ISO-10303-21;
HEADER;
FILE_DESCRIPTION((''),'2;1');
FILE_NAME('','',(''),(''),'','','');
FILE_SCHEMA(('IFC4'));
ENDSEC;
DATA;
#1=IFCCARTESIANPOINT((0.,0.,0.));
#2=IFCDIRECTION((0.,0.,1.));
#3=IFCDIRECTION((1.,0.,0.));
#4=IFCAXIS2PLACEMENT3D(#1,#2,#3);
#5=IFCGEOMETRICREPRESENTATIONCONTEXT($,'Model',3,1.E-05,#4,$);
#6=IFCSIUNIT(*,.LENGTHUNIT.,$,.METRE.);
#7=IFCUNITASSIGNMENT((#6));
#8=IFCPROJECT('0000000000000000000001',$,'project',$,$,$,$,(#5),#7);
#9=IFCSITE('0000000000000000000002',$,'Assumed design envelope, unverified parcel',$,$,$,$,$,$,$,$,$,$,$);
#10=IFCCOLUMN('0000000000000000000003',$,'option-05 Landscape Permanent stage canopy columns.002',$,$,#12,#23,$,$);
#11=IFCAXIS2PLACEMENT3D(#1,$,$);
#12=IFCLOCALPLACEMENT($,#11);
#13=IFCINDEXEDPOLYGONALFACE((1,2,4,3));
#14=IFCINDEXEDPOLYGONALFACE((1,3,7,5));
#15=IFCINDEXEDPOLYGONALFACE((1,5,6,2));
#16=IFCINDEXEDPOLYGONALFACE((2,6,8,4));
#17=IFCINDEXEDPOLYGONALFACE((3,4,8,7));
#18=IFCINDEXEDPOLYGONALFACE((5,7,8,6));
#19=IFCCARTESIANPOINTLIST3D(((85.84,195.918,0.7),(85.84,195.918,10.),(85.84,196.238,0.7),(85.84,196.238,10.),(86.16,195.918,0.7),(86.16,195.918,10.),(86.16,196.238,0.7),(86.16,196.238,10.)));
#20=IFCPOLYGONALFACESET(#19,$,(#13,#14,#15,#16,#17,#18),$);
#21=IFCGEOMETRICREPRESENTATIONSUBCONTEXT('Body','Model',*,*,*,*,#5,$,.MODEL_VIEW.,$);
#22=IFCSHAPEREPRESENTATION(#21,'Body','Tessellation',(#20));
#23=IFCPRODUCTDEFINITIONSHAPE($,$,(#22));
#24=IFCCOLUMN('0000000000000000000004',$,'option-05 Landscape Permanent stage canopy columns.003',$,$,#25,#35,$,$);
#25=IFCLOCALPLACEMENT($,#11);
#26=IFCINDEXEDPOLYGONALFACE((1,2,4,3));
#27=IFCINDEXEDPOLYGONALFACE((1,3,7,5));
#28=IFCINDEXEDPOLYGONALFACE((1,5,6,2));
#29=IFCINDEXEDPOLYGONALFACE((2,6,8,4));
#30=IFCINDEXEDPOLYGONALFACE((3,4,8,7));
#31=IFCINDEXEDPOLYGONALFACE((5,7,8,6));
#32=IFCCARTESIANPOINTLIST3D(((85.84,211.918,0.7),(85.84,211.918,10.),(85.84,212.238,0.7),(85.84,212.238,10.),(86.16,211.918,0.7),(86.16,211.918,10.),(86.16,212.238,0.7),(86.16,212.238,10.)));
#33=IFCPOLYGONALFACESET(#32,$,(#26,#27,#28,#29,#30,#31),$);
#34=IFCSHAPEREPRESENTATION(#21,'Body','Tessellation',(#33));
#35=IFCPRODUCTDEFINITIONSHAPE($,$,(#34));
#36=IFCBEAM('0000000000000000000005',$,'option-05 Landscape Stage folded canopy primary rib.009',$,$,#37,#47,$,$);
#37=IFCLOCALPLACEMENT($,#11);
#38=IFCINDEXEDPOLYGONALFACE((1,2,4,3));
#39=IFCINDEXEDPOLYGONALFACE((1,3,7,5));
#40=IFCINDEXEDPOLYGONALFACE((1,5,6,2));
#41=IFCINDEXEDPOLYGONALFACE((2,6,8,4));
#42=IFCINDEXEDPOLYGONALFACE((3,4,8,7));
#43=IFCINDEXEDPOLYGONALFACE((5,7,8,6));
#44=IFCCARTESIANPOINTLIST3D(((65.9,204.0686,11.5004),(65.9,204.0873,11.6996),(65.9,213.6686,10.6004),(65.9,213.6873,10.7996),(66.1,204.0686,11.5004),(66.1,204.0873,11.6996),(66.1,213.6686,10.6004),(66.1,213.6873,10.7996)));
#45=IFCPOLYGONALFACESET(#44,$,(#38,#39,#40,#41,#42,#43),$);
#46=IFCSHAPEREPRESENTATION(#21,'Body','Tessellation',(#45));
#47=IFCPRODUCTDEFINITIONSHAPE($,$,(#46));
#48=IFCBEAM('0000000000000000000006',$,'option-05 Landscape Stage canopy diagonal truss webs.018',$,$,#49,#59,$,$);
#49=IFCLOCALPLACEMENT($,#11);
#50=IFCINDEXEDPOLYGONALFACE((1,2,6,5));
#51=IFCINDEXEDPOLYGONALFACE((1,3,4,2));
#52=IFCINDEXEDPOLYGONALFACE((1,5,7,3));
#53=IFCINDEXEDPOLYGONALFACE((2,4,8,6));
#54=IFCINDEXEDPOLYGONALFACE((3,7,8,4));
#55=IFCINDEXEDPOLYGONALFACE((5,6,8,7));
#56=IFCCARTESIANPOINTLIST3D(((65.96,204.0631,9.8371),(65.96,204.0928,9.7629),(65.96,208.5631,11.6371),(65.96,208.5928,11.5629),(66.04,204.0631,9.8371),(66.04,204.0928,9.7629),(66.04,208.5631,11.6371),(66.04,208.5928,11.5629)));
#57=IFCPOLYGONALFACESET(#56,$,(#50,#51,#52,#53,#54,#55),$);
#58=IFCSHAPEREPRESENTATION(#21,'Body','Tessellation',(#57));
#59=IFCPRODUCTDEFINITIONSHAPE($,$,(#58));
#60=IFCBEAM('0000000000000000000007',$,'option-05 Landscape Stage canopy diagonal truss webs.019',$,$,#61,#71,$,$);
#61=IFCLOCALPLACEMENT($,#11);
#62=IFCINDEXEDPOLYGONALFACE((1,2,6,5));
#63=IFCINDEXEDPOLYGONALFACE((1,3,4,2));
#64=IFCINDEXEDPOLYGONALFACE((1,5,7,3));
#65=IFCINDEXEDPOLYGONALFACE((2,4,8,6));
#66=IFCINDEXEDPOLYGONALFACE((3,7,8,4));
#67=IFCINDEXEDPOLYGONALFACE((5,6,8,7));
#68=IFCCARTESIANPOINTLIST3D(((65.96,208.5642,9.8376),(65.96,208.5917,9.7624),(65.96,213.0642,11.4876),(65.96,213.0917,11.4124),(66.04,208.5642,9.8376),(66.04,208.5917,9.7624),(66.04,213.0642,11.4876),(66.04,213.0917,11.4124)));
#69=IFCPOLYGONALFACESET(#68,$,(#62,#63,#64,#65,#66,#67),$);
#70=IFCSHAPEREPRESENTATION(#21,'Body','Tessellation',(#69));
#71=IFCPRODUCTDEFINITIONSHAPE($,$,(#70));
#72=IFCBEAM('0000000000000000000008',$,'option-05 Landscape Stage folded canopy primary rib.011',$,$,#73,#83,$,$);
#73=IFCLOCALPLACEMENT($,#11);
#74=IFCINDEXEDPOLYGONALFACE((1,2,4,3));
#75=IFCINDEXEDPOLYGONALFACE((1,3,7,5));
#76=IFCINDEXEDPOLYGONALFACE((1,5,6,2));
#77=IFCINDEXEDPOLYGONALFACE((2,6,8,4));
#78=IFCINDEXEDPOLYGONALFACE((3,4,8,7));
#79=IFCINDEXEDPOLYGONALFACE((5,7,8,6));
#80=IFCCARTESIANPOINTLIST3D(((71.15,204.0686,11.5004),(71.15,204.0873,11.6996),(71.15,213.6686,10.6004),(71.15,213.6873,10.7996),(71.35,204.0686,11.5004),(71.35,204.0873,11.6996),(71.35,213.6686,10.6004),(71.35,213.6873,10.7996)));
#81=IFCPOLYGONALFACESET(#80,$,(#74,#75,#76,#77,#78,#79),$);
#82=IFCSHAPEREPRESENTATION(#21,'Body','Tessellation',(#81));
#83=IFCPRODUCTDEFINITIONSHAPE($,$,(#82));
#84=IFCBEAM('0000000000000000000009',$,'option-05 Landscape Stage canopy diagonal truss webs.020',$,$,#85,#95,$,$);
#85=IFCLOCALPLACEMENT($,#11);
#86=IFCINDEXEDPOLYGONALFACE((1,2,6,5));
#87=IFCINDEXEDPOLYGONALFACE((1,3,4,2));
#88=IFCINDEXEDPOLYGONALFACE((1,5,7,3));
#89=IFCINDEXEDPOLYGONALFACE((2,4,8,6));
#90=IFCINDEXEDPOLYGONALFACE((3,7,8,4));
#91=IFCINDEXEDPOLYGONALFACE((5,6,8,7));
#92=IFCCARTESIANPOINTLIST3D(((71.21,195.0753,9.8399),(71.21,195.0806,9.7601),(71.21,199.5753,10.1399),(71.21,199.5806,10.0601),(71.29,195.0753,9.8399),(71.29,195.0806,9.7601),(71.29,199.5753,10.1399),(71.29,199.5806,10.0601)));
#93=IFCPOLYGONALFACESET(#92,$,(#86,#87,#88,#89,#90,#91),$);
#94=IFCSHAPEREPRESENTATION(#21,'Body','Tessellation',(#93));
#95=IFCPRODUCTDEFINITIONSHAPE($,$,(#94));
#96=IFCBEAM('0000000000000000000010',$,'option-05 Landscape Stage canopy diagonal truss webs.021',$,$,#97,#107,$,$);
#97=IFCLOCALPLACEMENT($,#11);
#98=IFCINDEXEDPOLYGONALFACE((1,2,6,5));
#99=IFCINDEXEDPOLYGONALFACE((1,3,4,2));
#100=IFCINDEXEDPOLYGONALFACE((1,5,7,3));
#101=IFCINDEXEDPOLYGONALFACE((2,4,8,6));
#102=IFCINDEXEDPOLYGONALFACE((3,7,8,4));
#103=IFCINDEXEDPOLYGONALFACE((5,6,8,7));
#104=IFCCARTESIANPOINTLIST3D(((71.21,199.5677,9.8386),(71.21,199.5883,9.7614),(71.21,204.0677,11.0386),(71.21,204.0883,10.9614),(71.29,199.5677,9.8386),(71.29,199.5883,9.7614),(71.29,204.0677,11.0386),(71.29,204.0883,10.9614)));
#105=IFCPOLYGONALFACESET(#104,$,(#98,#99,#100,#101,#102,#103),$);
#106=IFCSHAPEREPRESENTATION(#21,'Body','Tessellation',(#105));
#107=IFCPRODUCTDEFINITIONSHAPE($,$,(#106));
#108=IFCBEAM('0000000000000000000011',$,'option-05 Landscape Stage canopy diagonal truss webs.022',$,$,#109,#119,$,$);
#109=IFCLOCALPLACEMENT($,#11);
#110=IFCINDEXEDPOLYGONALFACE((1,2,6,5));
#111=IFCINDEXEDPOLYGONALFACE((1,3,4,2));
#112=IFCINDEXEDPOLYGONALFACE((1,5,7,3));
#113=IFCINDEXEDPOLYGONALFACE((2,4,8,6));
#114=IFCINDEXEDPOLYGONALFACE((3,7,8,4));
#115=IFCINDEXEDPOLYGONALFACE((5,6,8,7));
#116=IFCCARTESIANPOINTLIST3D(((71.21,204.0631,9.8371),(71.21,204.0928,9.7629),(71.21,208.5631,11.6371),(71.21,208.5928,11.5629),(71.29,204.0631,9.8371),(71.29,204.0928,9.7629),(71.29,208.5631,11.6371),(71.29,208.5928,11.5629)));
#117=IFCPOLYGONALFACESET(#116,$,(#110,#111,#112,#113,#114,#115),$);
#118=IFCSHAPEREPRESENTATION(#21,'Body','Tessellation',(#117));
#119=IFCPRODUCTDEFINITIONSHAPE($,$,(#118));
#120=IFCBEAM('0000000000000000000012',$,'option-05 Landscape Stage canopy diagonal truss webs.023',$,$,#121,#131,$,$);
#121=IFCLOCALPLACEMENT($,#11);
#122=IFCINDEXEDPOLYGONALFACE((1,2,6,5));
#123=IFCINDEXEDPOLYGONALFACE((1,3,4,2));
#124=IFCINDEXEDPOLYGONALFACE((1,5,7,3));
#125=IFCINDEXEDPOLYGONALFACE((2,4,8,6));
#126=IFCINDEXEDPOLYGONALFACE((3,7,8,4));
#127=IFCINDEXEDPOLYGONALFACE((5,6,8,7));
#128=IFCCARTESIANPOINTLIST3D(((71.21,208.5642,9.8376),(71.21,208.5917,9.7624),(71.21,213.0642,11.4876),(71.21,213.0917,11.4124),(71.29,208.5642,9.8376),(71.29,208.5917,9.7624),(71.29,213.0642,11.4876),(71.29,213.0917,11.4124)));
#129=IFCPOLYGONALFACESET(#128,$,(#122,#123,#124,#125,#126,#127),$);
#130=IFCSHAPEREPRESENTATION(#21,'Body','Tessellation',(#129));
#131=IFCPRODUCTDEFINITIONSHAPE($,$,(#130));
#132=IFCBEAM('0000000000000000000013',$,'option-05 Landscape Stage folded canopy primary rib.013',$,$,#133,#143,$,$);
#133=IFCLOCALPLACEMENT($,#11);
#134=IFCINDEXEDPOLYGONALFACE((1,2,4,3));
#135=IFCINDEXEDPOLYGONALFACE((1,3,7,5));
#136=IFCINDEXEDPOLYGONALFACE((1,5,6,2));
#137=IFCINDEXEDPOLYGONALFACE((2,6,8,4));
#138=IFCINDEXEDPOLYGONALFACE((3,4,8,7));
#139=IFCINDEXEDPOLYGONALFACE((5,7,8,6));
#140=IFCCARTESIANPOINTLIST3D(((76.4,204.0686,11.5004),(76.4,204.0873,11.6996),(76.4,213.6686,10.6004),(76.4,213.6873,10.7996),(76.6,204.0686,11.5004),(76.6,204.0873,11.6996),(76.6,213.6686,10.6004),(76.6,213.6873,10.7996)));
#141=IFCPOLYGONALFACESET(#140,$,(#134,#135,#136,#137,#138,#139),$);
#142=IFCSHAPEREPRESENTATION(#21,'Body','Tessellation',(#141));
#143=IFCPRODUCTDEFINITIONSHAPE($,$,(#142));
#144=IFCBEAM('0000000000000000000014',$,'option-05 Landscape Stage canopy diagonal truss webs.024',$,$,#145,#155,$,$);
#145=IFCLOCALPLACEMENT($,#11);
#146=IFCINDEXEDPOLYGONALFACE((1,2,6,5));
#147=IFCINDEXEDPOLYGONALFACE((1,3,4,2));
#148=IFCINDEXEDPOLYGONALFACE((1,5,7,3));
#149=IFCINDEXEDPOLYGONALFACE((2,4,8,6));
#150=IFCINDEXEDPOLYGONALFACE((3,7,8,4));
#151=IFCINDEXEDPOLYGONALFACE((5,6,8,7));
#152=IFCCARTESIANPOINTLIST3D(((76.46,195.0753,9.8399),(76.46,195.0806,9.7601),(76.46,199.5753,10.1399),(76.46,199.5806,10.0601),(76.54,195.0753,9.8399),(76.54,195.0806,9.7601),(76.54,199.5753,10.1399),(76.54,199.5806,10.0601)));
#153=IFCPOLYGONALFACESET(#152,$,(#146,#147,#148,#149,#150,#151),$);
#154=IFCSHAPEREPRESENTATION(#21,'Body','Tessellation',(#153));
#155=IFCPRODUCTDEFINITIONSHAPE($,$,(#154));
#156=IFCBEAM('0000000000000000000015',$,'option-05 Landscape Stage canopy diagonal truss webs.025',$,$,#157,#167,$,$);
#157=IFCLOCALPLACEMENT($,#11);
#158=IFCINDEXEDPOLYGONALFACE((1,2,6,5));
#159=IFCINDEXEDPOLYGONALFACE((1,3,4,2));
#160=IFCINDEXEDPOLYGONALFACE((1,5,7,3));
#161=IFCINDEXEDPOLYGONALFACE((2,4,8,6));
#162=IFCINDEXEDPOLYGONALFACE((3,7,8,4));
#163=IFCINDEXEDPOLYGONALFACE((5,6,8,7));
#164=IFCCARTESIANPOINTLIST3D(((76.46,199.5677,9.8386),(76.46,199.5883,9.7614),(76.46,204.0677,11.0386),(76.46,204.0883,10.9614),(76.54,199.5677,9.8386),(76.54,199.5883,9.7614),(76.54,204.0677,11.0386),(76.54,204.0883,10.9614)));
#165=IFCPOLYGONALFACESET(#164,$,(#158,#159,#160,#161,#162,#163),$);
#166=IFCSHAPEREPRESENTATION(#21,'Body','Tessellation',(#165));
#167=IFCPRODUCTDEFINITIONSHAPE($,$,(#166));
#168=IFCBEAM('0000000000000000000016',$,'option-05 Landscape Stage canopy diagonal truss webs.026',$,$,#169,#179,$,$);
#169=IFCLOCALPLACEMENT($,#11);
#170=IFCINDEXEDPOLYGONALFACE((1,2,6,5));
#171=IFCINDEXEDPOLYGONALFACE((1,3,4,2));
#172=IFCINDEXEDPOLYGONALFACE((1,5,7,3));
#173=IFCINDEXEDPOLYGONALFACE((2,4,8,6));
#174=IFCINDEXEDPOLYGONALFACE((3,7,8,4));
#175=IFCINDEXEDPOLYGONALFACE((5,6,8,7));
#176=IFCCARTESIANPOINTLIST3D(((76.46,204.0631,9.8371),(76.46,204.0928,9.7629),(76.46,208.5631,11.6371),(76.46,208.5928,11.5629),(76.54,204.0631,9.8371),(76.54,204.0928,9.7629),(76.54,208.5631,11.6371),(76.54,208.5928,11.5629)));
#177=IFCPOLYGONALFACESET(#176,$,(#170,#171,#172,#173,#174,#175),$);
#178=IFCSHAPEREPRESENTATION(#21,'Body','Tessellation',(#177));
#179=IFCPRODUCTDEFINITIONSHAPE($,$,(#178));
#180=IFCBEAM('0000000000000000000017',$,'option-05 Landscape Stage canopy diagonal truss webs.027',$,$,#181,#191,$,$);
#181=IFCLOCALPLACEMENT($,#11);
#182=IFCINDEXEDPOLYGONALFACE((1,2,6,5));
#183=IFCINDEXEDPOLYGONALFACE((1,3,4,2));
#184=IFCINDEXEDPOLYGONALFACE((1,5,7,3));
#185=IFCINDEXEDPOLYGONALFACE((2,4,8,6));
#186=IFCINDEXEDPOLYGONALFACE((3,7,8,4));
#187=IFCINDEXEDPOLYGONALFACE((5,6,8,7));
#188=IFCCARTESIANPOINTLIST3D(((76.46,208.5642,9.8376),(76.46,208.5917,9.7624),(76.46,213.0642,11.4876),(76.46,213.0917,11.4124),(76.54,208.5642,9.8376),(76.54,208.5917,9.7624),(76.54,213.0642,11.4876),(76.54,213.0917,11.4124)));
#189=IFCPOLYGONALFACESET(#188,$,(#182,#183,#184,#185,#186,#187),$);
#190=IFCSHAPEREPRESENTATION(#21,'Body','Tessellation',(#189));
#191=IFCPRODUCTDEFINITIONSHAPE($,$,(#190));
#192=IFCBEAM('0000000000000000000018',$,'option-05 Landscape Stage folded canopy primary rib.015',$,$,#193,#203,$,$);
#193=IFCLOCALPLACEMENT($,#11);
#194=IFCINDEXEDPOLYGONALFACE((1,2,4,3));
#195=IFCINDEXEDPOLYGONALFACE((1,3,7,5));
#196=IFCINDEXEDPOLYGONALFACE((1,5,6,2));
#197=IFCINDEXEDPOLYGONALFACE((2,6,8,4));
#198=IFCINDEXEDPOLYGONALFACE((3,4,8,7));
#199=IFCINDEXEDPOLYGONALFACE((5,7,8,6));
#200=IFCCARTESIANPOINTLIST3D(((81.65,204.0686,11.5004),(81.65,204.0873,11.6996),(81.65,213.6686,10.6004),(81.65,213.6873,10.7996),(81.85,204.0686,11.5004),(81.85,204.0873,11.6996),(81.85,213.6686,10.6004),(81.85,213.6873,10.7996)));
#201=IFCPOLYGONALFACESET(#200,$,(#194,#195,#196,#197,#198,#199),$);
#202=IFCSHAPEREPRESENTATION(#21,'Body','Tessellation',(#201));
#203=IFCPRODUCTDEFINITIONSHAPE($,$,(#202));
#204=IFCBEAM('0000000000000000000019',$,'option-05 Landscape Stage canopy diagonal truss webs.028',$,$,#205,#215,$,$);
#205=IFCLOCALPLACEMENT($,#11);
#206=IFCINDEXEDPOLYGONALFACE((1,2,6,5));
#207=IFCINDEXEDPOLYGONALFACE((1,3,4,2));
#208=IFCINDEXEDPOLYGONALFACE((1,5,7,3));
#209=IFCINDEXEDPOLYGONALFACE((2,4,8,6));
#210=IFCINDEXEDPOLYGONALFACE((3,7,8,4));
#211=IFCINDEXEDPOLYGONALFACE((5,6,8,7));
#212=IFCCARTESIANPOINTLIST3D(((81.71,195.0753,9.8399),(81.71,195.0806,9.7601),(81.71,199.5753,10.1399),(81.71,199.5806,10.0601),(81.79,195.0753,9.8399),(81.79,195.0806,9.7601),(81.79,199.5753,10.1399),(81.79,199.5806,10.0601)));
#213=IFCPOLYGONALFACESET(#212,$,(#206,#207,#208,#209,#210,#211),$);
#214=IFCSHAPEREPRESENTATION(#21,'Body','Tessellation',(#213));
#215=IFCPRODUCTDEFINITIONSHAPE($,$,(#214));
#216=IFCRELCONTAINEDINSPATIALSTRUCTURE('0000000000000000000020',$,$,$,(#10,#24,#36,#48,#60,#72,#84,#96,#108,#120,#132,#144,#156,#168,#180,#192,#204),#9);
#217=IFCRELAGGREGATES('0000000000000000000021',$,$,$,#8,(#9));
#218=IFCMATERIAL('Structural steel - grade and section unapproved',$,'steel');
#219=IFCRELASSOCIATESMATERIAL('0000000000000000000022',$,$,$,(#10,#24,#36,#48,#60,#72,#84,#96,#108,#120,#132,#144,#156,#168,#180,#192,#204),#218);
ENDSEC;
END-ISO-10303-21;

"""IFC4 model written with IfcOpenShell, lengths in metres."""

from ifc_helpers import new_model, si_unit, frame, origin_with_axes, place, context, subcontext, project, spatial, rectangle, extrude, material, element, save


model = new_model("IFC4")

# Units and contexts
model_context = context("Model", 3, precision=1e-05, world=origin_with_axes())
body_context = subcontext(model_context, "Body", "Model", "MODEL_VIEW")
ifc_project = project(units=[si_unit("LENGTHUNIT", "METRE")], contexts=[model_context])

# Site
site = spatial("IfcSite", under=ifc_project, Name="Assumed design envelope, unverified parcel")

# Columns
ifc_material = material(Name="Structural steel - grade and section unapproved", Category="steel")
for number, where, z_axis, x_axis, name in (
    (1, (86.0, 196.078, 0.7), (0.0, 0.0, 1.0), (-1.0, 0.0, 0.0), "option-05 Landscape Permanent stage canopy columns.002"),
    (2, (86.0, 212.078, 0.7), (0.0, 0.0, 1.0), (-1.0, 0.0, 0.0), "option-05 Landscape Permanent stage canopy columns.003"),
):
    element("IfcColumn", number, at=place(None, frame(where, z_axis=z_axis, x_axis=x_axis)), inside=site, material=ifc_material, Name=name, context=body_context, shape_type="SweptSolid", body=[
        extrude(rectangle(XDim=0.32, YDim=0.32), origin_with_axes(), (0.0, 0.0, 1.0), 9.3),
    ])

# Beams
beam_1_placement = place(None, frame((66.0, 204.078, 11.6), z_axis=(0.0, 0.995634, -0.093341), x_axis=(-1.0, 0.0, 0.0)))
element("IfcBeam", 3, at=beam_1_placement, inside=site, material=ifc_material, Name="option-05 Landscape Stage folded canopy primary rib.009", context=body_context, shape_type="SweptSolid", body=[
    extrude(rectangle(XDim=0.2, YDim=0.2), origin_with_axes(), (0.0, 0.0, 1.0), 9.6421),
])
beam_2_placement = place(None, frame((66.0, 204.078, 9.8), z_axis=(0.0, 0.928477, 0.371391), x_axis=(-1.0, 0.0, 0.0)))
element("IfcBeam", 4, at=beam_2_placement, inside=site, material=ifc_material, Name="option-05 Landscape Stage canopy diagonal truss webs.018", context=body_context, shape_type="SweptSolid", body=[
    extrude(rectangle(XDim=0.08, YDim=0.08), origin_with_axes(), (0.0, 0.0, 1.0), 4.8466),
])
beam_3_placement = place(None, frame((66.0, 208.578, 9.8), z_axis=(0.0, 0.938876, 0.344255), x_axis=(-1.0, 0.0, 0.0)))
element("IfcBeam", 5, at=beam_3_placement, inside=site, material=ifc_material, Name="option-05 Landscape Stage canopy diagonal truss webs.019", context=body_context, shape_type="SweptSolid", body=[
    extrude(rectangle(XDim=0.08, YDim=0.08), origin_with_axes(), (0.0, 0.0, 1.0), 4.793),
])
beam_4_placement = place(None, frame((71.25, 204.078, 11.6), z_axis=(0.0, 0.995634, -0.093341), x_axis=(-1.0, 0.0, 0.0)))
element("IfcBeam", 6, at=beam_4_placement, inside=site, material=ifc_material, Name="option-05 Landscape Stage folded canopy primary rib.011", context=body_context, shape_type="SweptSolid", body=[
    extrude(rectangle(XDim=0.2, YDim=0.2), origin_with_axes(), (0.0, 0.0, 1.0), 9.6421),
])
beam_5_placement = place(None, frame((71.25, 195.078, 9.8), z_axis=(0.0, 0.997785, 0.066519), x_axis=(-1.0, 0.0, 0.0)))
element("IfcBeam", 7, at=beam_5_placement, inside=site, material=ifc_material, Name="option-05 Landscape Stage canopy diagonal truss webs.020", context=body_context, shape_type="SweptSolid", body=[
    extrude(rectangle(XDim=0.08, YDim=0.08), origin_with_axes(), (0.0, 0.0, 1.0), 4.51),
])
beam_6_placement = place(None, frame((71.25, 199.578, 9.8), z_axis=(0.0, 0.966235, 0.257663), x_axis=(-1.0, 0.0, 0.0)))
element("IfcBeam", 8, at=beam_6_placement, inside=site, material=ifc_material, Name="option-05 Landscape Stage canopy diagonal truss webs.021", context=body_context, shape_type="SweptSolid", body=[
    extrude(rectangle(XDim=0.08, YDim=0.08), origin_with_axes(), (0.0, 0.0, 1.0), 4.6573),
])
beam_7_placement = place(None, frame((71.25, 204.078, 9.8), z_axis=(0.0, 0.928477, 0.371391), x_axis=(-1.0, 0.0, 0.0)))
element("IfcBeam", 9, at=beam_7_placement, inside=site, material=ifc_material, Name="option-05 Landscape Stage canopy diagonal truss webs.022", context=body_context, shape_type="SweptSolid", body=[
    extrude(rectangle(XDim=0.08, YDim=0.08), origin_with_axes(), (0.0, 0.0, 1.0), 4.8466),
])
beam_8_placement = place(None, frame((71.25, 208.578, 9.8), z_axis=(0.0, 0.938876, 0.344255), x_axis=(-1.0, 0.0, 0.0)))
element("IfcBeam", 10, at=beam_8_placement, inside=site, material=ifc_material, Name="option-05 Landscape Stage canopy diagonal truss webs.023", context=body_context, shape_type="SweptSolid", body=[
    extrude(rectangle(XDim=0.08, YDim=0.08), origin_with_axes(), (0.0, 0.0, 1.0), 4.793),
])
beam_9_placement = place(None, frame((76.5, 204.078, 11.6), z_axis=(0.0, 0.995634, -0.093341), x_axis=(-1.0, 0.0, 0.0)))
element("IfcBeam", 11, at=beam_9_placement, inside=site, material=ifc_material, Name="option-05 Landscape Stage folded canopy primary rib.013", context=body_context, shape_type="SweptSolid", body=[
    extrude(rectangle(XDim=0.2, YDim=0.2), origin_with_axes(), (0.0, 0.0, 1.0), 9.6421),
])
beam_10_placement = place(None, frame((76.5, 195.078, 9.8), z_axis=(0.0, 0.997785, 0.066519), x_axis=(-1.0, 0.0, 0.0)))
element("IfcBeam", 12, at=beam_10_placement, inside=site, material=ifc_material, Name="option-05 Landscape Stage canopy diagonal truss webs.024", context=body_context, shape_type="SweptSolid", body=[
    extrude(rectangle(XDim=0.08, YDim=0.08), origin_with_axes(), (0.0, 0.0, 1.0), 4.51),
])
beam_11_placement = place(None, frame((76.5, 199.578, 9.8), z_axis=(0.0, 0.966235, 0.257663), x_axis=(-1.0, 0.0, 0.0)))
element("IfcBeam", 13, at=beam_11_placement, inside=site, material=ifc_material, Name="option-05 Landscape Stage canopy diagonal truss webs.025", context=body_context, shape_type="SweptSolid", body=[
    extrude(rectangle(XDim=0.08, YDim=0.08), origin_with_axes(), (0.0, 0.0, 1.0), 4.6573),
])
beam_12_placement = place(None, frame((76.5, 204.078, 9.8), z_axis=(0.0, 0.928477, 0.371391), x_axis=(-1.0, 0.0, 0.0)))
element("IfcBeam", 14, at=beam_12_placement, inside=site, material=ifc_material, Name="option-05 Landscape Stage canopy diagonal truss webs.026", context=body_context, shape_type="SweptSolid", body=[
    extrude(rectangle(XDim=0.08, YDim=0.08), origin_with_axes(), (0.0, 0.0, 1.0), 4.8466),
])
beam_13_placement = place(None, frame((76.5, 208.578, 9.8), z_axis=(0.0, 0.938876, 0.344255), x_axis=(-1.0, 0.0, 0.0)))
element("IfcBeam", 15, at=beam_13_placement, inside=site, material=ifc_material, Name="option-05 Landscape Stage canopy diagonal truss webs.027", context=body_context, shape_type="SweptSolid", body=[
    extrude(rectangle(XDim=0.08, YDim=0.08), origin_with_axes(), (0.0, 0.0, 1.0), 4.793),
])
beam_14_placement = place(None, frame((81.75, 204.078, 11.6), z_axis=(0.0, 0.995634, -0.093341), x_axis=(-1.0, 0.0, 0.0)))
element("IfcBeam", 16, at=beam_14_placement, inside=site, material=ifc_material, Name="option-05 Landscape Stage folded canopy primary rib.015", context=body_context, shape_type="SweptSolid", body=[
    extrude(rectangle(XDim=0.2, YDim=0.2), origin_with_axes(), (0.0, 0.0, 1.0), 9.6421),
])
beam_15_placement = place(None, frame((81.75, 195.078, 9.8), z_axis=(0.0, 0.997785, 0.066519), x_axis=(-1.0, 0.0, 0.0)))
element("IfcBeam", 17, at=beam_15_placement, inside=site, material=ifc_material, Name="option-05 Landscape Stage canopy diagonal truss webs.028", context=body_context, shape_type="SweptSolid", body=[
    extrude(rectangle(XDim=0.08, YDim=0.08), origin_with_axes(), (0.0, 0.0, 1.0), 4.51),
])

save(model, "model.ifc")
